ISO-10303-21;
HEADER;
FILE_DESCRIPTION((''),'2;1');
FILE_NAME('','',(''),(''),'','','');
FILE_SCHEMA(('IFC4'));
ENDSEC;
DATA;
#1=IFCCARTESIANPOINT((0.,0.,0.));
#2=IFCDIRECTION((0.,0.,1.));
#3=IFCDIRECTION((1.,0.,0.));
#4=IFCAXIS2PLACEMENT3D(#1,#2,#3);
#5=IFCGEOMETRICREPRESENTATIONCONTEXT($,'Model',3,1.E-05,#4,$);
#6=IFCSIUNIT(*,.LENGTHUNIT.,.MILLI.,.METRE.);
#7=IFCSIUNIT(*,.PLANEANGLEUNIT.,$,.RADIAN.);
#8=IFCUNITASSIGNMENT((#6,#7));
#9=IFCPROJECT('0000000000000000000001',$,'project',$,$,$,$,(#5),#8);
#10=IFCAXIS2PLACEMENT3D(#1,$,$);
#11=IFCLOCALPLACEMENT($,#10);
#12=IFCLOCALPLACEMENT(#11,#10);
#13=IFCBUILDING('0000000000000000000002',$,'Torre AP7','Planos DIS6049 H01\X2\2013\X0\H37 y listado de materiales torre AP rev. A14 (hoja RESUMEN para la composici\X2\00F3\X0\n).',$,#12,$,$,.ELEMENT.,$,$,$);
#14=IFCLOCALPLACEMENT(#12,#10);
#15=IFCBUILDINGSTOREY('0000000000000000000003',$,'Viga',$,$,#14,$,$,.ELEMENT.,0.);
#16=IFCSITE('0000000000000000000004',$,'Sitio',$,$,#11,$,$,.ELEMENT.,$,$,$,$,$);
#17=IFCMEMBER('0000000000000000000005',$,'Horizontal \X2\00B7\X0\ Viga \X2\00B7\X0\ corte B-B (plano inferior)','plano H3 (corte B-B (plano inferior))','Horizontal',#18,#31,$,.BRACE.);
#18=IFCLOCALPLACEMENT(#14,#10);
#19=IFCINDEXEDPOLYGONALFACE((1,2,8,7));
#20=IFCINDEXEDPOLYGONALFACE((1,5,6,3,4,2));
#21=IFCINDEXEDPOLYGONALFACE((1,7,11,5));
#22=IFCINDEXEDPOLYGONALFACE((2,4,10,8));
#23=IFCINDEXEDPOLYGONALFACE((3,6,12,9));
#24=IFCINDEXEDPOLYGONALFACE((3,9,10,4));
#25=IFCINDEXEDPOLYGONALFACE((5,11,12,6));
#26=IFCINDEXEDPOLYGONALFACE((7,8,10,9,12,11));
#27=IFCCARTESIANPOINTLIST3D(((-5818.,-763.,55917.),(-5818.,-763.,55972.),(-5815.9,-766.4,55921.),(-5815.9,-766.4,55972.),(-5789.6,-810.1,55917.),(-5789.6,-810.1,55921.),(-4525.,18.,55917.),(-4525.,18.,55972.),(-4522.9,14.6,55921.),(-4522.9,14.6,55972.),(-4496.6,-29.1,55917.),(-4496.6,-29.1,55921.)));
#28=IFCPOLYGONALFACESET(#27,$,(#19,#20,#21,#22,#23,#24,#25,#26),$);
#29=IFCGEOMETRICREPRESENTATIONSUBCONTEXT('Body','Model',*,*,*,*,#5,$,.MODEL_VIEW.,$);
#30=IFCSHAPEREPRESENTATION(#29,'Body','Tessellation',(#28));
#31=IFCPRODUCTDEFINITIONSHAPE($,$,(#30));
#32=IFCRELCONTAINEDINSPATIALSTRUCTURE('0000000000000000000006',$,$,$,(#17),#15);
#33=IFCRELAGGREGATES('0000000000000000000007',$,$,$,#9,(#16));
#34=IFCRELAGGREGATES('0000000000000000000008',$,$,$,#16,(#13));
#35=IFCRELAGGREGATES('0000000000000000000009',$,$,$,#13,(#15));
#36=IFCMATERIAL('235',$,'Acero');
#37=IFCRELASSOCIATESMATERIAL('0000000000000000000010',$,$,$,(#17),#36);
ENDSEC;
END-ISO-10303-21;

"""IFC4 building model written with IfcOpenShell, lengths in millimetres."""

from ifc_helpers import new_model, si_unit, frame, frame_2d, origin, origin_with_axes, place, context, subcontext, project, spatial, l_section, extrude, material, element, save


model = new_model("IFC4")

# Units and contexts
model_context = context("Model", 3, precision=1e-05, world=origin_with_axes())
body_context = subcontext(model_context, "Body", "Model", "MODEL_VIEW")
ifc_project = project(units=[si_unit("LENGTHUNIT", "METRE", prefix="MILLI"), si_unit("PLANEANGLEUNIT", "RADIAN")], contexts=[model_context])

# Site, building, storey
site_placement = place(None, origin())
site = spatial("IfcSite", under=ifc_project, at=site_placement, Name="Sitio", CompositionType="ELEMENT")
building_placement = place(site_placement, origin())
building = spatial("IfcBuilding", under=site, at=building_placement, Name="Torre AP7", Description="Planos DIS6049 H01–H37 y listado de materiales torre AP rev. A14 (hoja RESUMEN para la composición).", CompositionType="ELEMENT")
storey_placement = place(building_placement, origin())
storey = spatial("IfcBuildingStorey", under=building, at=storey_placement, Name="Viga", CompositionType="ELEMENT", Elevation=0.0)

# Member
ifc_material = material(Name="235", Category="Acero")
member_1_placement = place(storey_placement, frame((-4525.0, 18.0, 55917.0), z_axis=(-0.85597, -0.517025, 0.0), x_axis=(0.517025, -0.85597, 0.0)))
element("IfcMember", 1, at=member_1_placement, inside=storey, material=ifc_material, Name="Horizontal · Viga · corte B-B (plano inferior)", Description="plano H3 (corte B-B (plano inferior))", ObjectType="Horizontal", PredefinedType="BRACE", context=body_context, shape_type="SweptSolid", body=[
    extrude(l_section(Depth=55.0, Width=55.0, Thickness=4.0, at=frame_2d((27.5, 27.5))), None, (0.0, 0.0, 1.0), 1510.6),
])

save(model, "model.ifc")
